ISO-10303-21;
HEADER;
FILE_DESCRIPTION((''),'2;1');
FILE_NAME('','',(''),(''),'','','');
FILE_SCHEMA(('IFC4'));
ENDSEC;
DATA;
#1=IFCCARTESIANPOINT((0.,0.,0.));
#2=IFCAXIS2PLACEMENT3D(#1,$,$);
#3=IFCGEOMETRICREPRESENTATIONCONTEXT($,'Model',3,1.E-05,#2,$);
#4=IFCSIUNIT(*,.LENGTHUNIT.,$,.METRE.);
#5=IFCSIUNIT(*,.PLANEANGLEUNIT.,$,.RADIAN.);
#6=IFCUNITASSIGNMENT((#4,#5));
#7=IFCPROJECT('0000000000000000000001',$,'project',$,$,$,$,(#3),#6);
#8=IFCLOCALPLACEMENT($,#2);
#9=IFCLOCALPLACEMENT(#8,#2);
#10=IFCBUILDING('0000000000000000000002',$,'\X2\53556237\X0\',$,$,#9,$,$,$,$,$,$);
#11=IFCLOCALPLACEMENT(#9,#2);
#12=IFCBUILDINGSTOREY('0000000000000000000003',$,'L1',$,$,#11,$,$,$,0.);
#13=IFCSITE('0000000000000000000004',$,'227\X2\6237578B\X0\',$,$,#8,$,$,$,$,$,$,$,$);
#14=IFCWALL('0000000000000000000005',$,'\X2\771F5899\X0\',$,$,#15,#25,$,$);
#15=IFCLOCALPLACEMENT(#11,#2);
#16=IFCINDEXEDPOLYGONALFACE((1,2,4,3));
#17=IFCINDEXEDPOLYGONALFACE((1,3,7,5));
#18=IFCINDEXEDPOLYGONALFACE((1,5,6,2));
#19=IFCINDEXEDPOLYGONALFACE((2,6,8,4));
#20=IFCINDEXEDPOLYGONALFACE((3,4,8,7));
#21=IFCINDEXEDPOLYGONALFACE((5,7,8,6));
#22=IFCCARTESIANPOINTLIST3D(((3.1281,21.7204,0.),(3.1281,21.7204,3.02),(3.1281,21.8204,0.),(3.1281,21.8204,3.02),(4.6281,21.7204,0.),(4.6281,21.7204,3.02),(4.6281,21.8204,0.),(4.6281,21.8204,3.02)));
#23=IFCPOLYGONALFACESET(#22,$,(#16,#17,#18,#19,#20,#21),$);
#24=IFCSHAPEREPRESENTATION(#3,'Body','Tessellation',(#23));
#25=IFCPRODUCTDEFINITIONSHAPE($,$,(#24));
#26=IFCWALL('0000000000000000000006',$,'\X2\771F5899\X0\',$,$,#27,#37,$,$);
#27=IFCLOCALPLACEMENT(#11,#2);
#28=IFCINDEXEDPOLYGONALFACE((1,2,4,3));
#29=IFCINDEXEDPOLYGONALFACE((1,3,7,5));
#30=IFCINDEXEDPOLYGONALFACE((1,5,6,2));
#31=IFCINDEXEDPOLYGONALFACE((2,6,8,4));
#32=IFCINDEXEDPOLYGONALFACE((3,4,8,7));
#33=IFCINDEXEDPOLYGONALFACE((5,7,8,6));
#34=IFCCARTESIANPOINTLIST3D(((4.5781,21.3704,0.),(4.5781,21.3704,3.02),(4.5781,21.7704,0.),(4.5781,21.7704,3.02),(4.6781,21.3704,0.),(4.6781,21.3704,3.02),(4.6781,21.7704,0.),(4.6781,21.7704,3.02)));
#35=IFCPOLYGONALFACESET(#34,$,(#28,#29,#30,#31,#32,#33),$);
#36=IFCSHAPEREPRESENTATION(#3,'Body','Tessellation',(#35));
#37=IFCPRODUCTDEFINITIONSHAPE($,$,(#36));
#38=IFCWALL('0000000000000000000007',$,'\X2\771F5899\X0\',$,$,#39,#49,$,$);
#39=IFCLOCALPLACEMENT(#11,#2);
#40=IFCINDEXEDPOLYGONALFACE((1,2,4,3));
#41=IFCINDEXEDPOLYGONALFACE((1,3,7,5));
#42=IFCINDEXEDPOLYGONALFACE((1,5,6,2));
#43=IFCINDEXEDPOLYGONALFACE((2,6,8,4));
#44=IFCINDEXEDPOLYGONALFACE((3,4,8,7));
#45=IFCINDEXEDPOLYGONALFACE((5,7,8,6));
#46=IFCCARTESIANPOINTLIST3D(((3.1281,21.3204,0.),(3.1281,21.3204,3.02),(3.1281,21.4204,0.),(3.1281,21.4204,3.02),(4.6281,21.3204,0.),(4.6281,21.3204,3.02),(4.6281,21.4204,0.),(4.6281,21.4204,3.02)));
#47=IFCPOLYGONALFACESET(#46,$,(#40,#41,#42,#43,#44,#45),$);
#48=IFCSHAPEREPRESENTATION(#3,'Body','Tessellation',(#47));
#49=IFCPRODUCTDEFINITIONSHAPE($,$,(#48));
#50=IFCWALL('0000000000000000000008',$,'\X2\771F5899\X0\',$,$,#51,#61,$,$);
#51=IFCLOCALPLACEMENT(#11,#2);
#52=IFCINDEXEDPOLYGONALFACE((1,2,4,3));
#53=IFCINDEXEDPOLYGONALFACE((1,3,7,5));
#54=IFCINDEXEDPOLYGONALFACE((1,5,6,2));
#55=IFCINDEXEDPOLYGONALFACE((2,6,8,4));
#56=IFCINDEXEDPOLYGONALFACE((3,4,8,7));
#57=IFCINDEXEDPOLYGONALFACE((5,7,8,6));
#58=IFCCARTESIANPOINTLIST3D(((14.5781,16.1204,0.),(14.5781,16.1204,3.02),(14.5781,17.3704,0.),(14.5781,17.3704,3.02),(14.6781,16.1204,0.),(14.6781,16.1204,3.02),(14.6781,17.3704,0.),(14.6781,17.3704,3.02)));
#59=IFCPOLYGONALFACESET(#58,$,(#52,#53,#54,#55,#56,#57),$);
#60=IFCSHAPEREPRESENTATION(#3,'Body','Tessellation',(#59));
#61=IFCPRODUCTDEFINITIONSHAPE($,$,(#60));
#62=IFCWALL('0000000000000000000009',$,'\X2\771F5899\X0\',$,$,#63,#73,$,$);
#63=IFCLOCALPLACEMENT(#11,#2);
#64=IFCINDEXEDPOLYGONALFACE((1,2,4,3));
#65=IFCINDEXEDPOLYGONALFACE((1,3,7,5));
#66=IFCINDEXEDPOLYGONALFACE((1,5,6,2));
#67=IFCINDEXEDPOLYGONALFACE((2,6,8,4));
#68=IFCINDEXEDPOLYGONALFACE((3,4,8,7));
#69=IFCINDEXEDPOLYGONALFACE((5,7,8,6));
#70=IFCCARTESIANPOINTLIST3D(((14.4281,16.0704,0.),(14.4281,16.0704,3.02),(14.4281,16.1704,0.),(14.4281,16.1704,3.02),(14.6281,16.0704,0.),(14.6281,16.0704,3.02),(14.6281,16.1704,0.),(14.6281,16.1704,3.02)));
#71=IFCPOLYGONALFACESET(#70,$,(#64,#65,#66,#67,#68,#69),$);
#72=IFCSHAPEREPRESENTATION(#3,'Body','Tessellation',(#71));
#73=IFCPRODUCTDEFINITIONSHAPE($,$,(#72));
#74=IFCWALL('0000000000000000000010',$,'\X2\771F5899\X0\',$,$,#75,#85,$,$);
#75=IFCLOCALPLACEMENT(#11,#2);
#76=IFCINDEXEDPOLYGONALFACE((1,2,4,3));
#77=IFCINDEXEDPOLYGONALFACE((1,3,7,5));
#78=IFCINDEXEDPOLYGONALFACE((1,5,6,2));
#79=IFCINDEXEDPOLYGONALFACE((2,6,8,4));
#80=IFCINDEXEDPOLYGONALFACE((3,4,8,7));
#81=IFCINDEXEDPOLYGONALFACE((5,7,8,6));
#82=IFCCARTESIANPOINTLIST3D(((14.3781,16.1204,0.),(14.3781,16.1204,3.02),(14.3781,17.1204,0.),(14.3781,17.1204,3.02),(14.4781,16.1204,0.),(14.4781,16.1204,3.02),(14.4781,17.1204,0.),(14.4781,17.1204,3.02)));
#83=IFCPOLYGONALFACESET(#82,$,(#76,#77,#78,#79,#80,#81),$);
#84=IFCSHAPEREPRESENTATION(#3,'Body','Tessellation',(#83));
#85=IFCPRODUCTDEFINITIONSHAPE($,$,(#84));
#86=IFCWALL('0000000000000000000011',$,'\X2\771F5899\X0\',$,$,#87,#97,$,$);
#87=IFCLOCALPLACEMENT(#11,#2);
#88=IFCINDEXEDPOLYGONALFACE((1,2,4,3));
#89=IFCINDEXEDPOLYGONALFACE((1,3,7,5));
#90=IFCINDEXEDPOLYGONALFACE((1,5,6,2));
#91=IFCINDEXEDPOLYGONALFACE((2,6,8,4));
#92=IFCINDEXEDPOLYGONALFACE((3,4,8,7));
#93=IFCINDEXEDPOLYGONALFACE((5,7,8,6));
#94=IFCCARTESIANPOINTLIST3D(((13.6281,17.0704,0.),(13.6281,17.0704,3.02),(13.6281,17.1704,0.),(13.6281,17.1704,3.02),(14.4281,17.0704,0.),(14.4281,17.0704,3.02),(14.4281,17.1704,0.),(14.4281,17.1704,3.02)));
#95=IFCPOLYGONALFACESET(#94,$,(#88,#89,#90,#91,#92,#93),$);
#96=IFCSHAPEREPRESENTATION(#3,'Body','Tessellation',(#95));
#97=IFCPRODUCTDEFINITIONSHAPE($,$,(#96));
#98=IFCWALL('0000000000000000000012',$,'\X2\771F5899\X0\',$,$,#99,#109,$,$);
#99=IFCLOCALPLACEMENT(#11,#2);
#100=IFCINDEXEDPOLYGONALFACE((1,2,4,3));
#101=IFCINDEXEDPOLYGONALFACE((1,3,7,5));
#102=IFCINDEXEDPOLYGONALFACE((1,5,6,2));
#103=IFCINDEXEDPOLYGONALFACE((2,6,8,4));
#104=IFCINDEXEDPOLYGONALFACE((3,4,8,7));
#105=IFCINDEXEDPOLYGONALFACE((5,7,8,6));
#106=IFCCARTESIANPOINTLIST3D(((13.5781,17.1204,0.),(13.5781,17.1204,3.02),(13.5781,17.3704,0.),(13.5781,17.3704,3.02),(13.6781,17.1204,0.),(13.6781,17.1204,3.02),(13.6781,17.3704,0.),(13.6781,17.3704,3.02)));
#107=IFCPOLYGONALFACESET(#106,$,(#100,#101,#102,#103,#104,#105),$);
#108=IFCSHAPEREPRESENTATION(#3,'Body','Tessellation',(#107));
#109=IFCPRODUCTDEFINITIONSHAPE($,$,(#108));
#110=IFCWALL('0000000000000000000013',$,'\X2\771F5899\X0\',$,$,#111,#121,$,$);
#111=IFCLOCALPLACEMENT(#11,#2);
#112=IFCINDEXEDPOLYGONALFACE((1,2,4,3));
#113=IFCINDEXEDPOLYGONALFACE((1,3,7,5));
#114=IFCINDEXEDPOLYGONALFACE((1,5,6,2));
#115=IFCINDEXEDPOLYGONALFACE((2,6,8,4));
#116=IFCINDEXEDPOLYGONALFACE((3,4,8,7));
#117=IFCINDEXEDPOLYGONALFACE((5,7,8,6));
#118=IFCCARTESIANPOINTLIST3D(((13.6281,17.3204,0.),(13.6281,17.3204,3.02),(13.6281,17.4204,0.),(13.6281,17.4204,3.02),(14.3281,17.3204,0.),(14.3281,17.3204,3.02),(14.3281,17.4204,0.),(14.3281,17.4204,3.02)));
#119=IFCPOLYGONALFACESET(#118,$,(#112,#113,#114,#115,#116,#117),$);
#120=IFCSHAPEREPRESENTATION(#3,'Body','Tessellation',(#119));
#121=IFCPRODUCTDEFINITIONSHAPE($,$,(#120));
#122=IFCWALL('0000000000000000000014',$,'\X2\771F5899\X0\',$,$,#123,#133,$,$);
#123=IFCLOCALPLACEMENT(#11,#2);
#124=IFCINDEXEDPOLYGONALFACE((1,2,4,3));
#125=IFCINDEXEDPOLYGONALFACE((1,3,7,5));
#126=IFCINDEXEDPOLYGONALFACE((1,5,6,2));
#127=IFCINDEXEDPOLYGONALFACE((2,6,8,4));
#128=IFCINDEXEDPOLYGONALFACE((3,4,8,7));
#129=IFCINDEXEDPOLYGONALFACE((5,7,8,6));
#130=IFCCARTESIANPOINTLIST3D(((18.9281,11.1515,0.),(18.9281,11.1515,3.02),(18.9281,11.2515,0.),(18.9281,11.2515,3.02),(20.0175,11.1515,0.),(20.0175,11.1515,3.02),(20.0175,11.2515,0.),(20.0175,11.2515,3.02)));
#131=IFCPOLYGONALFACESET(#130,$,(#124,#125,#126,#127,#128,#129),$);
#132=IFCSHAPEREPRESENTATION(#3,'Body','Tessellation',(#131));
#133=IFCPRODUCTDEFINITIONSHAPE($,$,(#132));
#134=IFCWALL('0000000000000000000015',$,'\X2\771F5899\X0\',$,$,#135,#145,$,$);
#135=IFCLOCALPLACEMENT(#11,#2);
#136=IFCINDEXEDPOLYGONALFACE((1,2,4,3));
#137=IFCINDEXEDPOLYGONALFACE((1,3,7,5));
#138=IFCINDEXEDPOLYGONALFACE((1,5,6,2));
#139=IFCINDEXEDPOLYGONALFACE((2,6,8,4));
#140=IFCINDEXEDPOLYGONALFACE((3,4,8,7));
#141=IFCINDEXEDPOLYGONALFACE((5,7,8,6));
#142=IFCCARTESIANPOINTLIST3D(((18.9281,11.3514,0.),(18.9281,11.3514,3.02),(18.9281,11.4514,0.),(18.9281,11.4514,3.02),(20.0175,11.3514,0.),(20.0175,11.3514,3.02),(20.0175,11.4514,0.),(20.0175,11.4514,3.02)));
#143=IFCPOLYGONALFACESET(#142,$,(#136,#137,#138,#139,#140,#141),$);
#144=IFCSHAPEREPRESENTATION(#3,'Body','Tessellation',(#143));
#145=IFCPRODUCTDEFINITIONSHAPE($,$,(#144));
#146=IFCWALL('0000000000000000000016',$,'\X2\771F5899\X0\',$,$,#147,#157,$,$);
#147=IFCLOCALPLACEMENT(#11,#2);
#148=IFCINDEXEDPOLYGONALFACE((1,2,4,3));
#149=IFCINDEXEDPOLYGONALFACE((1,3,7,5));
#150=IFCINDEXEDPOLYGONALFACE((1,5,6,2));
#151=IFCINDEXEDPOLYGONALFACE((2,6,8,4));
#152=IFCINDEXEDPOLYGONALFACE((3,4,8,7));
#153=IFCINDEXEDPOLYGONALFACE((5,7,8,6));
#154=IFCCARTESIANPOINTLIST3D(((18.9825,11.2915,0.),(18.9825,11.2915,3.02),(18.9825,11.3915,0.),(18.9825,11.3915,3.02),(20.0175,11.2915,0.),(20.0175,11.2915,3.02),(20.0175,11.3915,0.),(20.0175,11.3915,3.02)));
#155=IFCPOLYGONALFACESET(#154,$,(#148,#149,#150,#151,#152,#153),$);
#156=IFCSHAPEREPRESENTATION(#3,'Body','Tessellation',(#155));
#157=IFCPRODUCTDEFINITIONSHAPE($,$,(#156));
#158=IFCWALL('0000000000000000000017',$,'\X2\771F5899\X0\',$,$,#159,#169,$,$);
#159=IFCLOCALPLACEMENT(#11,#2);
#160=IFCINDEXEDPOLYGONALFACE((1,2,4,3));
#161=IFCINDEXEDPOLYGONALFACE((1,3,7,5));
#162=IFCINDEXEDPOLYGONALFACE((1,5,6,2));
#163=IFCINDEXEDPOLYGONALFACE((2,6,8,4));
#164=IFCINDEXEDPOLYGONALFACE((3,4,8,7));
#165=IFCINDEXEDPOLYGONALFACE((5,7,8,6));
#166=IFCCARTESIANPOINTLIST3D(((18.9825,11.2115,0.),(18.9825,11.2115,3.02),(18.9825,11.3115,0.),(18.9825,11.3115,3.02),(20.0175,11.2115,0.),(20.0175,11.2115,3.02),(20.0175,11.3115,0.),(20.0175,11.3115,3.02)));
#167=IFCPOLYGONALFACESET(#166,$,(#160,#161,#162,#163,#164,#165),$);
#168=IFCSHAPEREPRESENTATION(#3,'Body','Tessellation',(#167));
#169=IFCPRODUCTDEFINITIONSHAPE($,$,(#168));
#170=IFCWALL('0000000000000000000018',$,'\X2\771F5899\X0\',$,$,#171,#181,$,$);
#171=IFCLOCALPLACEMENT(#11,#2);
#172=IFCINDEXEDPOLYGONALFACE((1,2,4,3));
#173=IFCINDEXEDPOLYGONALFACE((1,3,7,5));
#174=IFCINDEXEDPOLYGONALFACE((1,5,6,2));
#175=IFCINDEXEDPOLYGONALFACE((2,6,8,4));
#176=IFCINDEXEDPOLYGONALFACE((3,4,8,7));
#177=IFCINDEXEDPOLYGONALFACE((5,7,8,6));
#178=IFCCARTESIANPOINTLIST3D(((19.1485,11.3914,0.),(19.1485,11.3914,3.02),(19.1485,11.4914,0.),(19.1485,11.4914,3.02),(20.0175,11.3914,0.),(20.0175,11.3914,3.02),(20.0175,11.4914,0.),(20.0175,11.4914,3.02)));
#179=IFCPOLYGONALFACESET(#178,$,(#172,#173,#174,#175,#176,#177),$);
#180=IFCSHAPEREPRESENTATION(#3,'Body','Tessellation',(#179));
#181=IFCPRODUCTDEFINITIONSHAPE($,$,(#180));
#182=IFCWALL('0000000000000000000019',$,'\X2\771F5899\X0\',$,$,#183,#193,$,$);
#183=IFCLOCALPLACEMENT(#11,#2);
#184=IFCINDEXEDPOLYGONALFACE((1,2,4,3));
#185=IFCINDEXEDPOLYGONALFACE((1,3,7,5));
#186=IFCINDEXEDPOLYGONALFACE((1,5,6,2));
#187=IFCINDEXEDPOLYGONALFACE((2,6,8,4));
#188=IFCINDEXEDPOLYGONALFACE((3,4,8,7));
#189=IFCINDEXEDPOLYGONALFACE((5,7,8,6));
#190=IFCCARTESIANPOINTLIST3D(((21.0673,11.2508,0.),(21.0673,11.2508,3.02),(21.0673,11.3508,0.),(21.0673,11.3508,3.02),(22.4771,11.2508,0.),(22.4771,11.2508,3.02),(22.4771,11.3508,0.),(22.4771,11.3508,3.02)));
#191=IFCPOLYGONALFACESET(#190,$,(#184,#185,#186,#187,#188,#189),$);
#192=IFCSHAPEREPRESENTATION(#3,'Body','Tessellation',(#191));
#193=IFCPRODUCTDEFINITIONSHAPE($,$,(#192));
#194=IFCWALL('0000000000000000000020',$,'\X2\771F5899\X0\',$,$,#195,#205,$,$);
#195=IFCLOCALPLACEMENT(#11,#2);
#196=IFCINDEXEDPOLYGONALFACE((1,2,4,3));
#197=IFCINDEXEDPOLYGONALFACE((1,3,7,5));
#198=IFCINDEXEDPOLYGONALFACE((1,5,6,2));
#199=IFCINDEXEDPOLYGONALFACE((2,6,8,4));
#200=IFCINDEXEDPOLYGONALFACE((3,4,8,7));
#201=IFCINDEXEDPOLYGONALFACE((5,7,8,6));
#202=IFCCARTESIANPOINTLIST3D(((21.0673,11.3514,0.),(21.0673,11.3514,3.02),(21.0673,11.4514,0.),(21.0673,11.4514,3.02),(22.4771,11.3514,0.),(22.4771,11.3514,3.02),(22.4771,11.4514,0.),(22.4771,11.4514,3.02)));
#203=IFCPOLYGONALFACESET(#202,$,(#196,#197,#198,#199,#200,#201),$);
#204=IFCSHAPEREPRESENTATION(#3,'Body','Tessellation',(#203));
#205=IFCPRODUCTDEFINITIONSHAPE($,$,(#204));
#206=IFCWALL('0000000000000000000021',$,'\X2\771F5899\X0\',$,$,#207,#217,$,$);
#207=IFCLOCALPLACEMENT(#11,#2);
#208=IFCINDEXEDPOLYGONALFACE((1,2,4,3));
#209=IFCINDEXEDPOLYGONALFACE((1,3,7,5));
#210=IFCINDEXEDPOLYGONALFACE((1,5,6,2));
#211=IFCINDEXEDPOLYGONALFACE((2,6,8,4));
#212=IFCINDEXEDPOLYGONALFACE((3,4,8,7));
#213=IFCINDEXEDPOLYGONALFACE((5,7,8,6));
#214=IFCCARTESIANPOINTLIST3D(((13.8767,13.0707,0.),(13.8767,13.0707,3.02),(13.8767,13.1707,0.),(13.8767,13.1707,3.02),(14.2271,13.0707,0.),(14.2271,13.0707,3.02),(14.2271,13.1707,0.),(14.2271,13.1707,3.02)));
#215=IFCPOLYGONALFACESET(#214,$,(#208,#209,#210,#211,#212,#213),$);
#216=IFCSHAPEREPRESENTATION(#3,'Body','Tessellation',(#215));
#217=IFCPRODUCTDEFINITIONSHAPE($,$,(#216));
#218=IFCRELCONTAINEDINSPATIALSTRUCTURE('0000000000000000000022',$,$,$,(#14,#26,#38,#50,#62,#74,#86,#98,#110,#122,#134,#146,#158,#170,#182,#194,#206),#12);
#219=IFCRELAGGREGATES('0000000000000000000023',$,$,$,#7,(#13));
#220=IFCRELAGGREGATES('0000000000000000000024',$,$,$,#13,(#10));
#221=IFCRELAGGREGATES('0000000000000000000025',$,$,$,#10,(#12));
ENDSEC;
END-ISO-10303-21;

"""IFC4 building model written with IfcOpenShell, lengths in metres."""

from ifc_helpers import new_model, si_unit, origin, place, context, project, spatial, polyline, outline, extrude, element, save


model = new_model("IFC4")

# Units and contexts
model_context = context("Model", 3, precision=1e-05, world=origin())
ifc_project = project(units=[si_unit("LENGTHUNIT", "METRE"), si_unit("PLANEANGLEUNIT", "RADIAN")], contexts=[model_context])

# Site, building, storey
site_placement = place(None, origin())
site = spatial("IfcSite", under=ifc_project, at=site_placement, Name="227户型")
building_placement = place(site_placement, origin())
building = spatial("IfcBuilding", under=site, at=building_placement, Name="单户")
storey_placement = place(building_placement, origin())
storey = spatial("IfcBuildingStorey", under=building, at=storey_placement, Name="L1", Elevation=0.0)

# Walls
wall_1_placement = place(storey_placement, origin())
element("IfcWall", 1, at=wall_1_placement, inside=storey, Name="真墙", context=model_context, shape_type="SweptSolid", body=[
    extrude(outline(polyline([(3.1281, 21.8204), (4.6281, 21.8204), (4.6281, 21.7204), (3.1281, 21.7204), (3.1281, 21.8204)])), origin(), (0.0, 0.0, 1.0), 3.02),
])
wall_2_placement = place(storey_placement, origin())
element("IfcWall", 2, at=wall_2_placement, inside=storey, Name="真墙", context=model_context, shape_type="SweptSolid", body=[
    extrude(outline(polyline([(4.6781, 21.7704), (4.6781, 21.3704), (4.5781, 21.3704), (4.5781, 21.7704), (4.6781, 21.7704)])), origin(), (0.0, 0.0, 1.0), 3.02),
])
wall_3_placement = place(storey_placement, origin())
element("IfcWall", 3, at=wall_3_placement, inside=storey, Name="真墙", context=model_context, shape_type="SweptSolid", body=[
    extrude(outline(polyline([(4.6281, 21.3204), (3.1281, 21.3204), (3.1281, 21.4204), (4.6281, 21.4204), (4.6281, 21.3204)])), origin(), (0.0, 0.0, 1.0), 3.02),
])
wall_4_placement = place(storey_placement, origin())
element("IfcWall", 4, at=wall_4_placement, inside=storey, Name="真墙", context=model_context, shape_type="SweptSolid", body=[
    extrude(outline(polyline([(14.6781, 17.3704), (14.6781, 16.1204), (14.5781, 16.1204), (14.5781, 17.3704), (14.6781, 17.3704)])), origin(), (0.0, 0.0, 1.0), 3.02),
])
wall_5_placement = place(storey_placement, origin())
element("IfcWall", 5, at=wall_5_placement, inside=storey, Name="真墙", context=model_context, shape_type="SweptSolid", body=[
    extrude(outline(polyline([(14.6281, 16.0704), (14.4281, 16.0704), (14.4281, 16.1704), (14.6281, 16.1704), (14.6281, 16.0704)])), origin(), (0.0, 0.0, 1.0), 3.02),
])
wall_6_placement = place(storey_placement, origin())
element("IfcWall", 6, at=wall_6_placement, inside=storey, Name="真墙", context=model_context, shape_type="SweptSolid", body=[
    extrude(outline(polyline([(14.3781, 16.1204), (14.3781, 17.1204), (14.4781, 17.1204), (14.4781, 16.1204), (14.3781, 16.1204)])), origin(), (0.0, 0.0, 1.0), 3.02),
])
wall_7_placement = place(storey_placement, origin())
element("IfcWall", 7, at=wall_7_placement, inside=storey, Name="真墙", context=model_context, shape_type="SweptSolid", body=[
    extrude(outline(polyline([(14.4281, 17.0704), (13.6281, 17.0704), (13.6281, 17.1704), (14.4281, 17.1704), (14.4281, 17.0704)])), origin(), (0.0, 0.0, 1.0), 3.02),
])
wall_8_placement = place(storey_placement, origin())
element("IfcWall", 8, at=wall_8_placement, inside=storey, Name="真墙", context=model_context, shape_type="SweptSolid", body=[
    extrude(outline(polyline([(13.5781, 17.1204), (13.5781, 17.3704), (13.6781, 17.3704), (13.6781, 17.1204), (13.5781, 17.1204)])), origin(), (0.0, 0.0, 1.0), 3.02),
])
wall_9_placement = place(storey_placement, origin())
element("IfcWall", 9, at=wall_9_placement, inside=storey, Name="真墙", context=model_context, shape_type="SweptSolid", body=[
    extrude(outline(polyline([(13.6281, 17.4204), (14.3281, 17.4204), (14.3281, 17.3204), (13.6281, 17.3204), (13.6281, 17.4204)])), origin(), (0.0, 0.0, 1.0), 3.02),
])

# Walls
wall_10_placement = place(storey_placement, origin())
element("IfcWall", 10, at=wall_10_placement, inside=storey, Name="真墙", context=model_context, shape_type="SweptSolid", body=[
    extrude(outline(polyline([(20.0175, 11.1515), (18.9281, 11.1515), (18.9281, 11.2515), (20.0175, 11.2515), (20.0175, 11.1515)])), origin(), (0.0, 0.0, 1.0), 3.02),
])
wall_11_placement = place(storey_placement, origin())
element("IfcWall", 11, at=wall_11_placement, inside=storey, Name="真墙", context=model_context, shape_type="SweptSolid", body=[
    extrude(outline(polyline([(18.9281, 11.4514), (20.0175, 11.4514), (20.0175, 11.3514), (18.9281, 11.3514), (18.9281, 11.4514)])), origin(), (0.0, 0.0, 1.0), 3.02),
])
wall_12_placement = place(storey_placement, origin())
element("IfcWall", 12, at=wall_12_placement, inside=storey, Name="真墙", context=model_context, shape_type="SweptSolid", body=[
    extrude(outline(polyline([(20.0175, 11.2915), (18.9825, 11.2915), (18.9825, 11.3915), (20.0175, 11.3915), (20.0175, 11.2915)])), origin(), (0.0, 0.0, 1.0), 3.02),
])
wall_13_placement = place(storey_placement, origin())
element("IfcWall", 13, at=wall_13_placement, inside=storey, Name="真墙", context=model_context, shape_type="SweptSolid", body=[
    extrude(outline(polyline([(18.9825, 11.3115), (20.0175, 11.3115), (20.0175, 11.2115), (18.9825, 11.2115), (18.9825, 11.3115)])), origin(), (0.0, 0.0, 1.0), 3.02),
])
wall_14_placement = place(storey_placement, origin())
element("IfcWall", 14, at=wall_14_placement, inside=storey, Name="真墙", context=model_context, shape_type="SweptSolid", body=[
    extrude(outline(polyline([(20.0175, 11.3914), (19.1485, 11.3914), (19.1485, 11.4914), (20.0175, 11.4914), (20.0175, 11.3914)])), origin(), (0.0, 0.0, 1.0), 3.02),
])
wall_15_placement = place(storey_placement, origin())
element("IfcWall", 15, at=wall_15_placement, inside=storey, Name="真墙", context=model_context, shape_type="SweptSolid", body=[
    extrude(outline(polyline([(21.0673, 11.3508), (22.4771, 11.3508), (22.4771, 11.2508), (21.0673, 11.2508), (21.0673, 11.3508)])), origin(), (0.0, 0.0, 1.0), 3.02),
])
wall_16_placement = place(storey_placement, origin())
element("IfcWall", 16, at=wall_16_placement, inside=storey, Name="真墙", context=model_context, shape_type="SweptSolid", body=[
    extrude(outline(polyline([(22.4771, 11.3514), (21.0673, 11.3514), (21.0673, 11.4514), (22.4771, 11.4514), (22.4771, 11.3514)])), origin(), (0.0, 0.0, 1.0), 3.02),
])
wall_17_placement = place(storey_placement, origin())
element("IfcWall", 17, at=wall_17_placement, inside=storey, Name="真墙", context=model_context, shape_type="SweptSolid", body=[
    extrude(outline(polyline([(14.2271, 13.0707), (13.8767, 13.0707), (13.8767, 13.1707), (14.2271, 13.1707), (14.2271, 13.0707)])), origin(), (0.0, 0.0, 1.0), 3.02),
])

save(model, "model.ifc")
